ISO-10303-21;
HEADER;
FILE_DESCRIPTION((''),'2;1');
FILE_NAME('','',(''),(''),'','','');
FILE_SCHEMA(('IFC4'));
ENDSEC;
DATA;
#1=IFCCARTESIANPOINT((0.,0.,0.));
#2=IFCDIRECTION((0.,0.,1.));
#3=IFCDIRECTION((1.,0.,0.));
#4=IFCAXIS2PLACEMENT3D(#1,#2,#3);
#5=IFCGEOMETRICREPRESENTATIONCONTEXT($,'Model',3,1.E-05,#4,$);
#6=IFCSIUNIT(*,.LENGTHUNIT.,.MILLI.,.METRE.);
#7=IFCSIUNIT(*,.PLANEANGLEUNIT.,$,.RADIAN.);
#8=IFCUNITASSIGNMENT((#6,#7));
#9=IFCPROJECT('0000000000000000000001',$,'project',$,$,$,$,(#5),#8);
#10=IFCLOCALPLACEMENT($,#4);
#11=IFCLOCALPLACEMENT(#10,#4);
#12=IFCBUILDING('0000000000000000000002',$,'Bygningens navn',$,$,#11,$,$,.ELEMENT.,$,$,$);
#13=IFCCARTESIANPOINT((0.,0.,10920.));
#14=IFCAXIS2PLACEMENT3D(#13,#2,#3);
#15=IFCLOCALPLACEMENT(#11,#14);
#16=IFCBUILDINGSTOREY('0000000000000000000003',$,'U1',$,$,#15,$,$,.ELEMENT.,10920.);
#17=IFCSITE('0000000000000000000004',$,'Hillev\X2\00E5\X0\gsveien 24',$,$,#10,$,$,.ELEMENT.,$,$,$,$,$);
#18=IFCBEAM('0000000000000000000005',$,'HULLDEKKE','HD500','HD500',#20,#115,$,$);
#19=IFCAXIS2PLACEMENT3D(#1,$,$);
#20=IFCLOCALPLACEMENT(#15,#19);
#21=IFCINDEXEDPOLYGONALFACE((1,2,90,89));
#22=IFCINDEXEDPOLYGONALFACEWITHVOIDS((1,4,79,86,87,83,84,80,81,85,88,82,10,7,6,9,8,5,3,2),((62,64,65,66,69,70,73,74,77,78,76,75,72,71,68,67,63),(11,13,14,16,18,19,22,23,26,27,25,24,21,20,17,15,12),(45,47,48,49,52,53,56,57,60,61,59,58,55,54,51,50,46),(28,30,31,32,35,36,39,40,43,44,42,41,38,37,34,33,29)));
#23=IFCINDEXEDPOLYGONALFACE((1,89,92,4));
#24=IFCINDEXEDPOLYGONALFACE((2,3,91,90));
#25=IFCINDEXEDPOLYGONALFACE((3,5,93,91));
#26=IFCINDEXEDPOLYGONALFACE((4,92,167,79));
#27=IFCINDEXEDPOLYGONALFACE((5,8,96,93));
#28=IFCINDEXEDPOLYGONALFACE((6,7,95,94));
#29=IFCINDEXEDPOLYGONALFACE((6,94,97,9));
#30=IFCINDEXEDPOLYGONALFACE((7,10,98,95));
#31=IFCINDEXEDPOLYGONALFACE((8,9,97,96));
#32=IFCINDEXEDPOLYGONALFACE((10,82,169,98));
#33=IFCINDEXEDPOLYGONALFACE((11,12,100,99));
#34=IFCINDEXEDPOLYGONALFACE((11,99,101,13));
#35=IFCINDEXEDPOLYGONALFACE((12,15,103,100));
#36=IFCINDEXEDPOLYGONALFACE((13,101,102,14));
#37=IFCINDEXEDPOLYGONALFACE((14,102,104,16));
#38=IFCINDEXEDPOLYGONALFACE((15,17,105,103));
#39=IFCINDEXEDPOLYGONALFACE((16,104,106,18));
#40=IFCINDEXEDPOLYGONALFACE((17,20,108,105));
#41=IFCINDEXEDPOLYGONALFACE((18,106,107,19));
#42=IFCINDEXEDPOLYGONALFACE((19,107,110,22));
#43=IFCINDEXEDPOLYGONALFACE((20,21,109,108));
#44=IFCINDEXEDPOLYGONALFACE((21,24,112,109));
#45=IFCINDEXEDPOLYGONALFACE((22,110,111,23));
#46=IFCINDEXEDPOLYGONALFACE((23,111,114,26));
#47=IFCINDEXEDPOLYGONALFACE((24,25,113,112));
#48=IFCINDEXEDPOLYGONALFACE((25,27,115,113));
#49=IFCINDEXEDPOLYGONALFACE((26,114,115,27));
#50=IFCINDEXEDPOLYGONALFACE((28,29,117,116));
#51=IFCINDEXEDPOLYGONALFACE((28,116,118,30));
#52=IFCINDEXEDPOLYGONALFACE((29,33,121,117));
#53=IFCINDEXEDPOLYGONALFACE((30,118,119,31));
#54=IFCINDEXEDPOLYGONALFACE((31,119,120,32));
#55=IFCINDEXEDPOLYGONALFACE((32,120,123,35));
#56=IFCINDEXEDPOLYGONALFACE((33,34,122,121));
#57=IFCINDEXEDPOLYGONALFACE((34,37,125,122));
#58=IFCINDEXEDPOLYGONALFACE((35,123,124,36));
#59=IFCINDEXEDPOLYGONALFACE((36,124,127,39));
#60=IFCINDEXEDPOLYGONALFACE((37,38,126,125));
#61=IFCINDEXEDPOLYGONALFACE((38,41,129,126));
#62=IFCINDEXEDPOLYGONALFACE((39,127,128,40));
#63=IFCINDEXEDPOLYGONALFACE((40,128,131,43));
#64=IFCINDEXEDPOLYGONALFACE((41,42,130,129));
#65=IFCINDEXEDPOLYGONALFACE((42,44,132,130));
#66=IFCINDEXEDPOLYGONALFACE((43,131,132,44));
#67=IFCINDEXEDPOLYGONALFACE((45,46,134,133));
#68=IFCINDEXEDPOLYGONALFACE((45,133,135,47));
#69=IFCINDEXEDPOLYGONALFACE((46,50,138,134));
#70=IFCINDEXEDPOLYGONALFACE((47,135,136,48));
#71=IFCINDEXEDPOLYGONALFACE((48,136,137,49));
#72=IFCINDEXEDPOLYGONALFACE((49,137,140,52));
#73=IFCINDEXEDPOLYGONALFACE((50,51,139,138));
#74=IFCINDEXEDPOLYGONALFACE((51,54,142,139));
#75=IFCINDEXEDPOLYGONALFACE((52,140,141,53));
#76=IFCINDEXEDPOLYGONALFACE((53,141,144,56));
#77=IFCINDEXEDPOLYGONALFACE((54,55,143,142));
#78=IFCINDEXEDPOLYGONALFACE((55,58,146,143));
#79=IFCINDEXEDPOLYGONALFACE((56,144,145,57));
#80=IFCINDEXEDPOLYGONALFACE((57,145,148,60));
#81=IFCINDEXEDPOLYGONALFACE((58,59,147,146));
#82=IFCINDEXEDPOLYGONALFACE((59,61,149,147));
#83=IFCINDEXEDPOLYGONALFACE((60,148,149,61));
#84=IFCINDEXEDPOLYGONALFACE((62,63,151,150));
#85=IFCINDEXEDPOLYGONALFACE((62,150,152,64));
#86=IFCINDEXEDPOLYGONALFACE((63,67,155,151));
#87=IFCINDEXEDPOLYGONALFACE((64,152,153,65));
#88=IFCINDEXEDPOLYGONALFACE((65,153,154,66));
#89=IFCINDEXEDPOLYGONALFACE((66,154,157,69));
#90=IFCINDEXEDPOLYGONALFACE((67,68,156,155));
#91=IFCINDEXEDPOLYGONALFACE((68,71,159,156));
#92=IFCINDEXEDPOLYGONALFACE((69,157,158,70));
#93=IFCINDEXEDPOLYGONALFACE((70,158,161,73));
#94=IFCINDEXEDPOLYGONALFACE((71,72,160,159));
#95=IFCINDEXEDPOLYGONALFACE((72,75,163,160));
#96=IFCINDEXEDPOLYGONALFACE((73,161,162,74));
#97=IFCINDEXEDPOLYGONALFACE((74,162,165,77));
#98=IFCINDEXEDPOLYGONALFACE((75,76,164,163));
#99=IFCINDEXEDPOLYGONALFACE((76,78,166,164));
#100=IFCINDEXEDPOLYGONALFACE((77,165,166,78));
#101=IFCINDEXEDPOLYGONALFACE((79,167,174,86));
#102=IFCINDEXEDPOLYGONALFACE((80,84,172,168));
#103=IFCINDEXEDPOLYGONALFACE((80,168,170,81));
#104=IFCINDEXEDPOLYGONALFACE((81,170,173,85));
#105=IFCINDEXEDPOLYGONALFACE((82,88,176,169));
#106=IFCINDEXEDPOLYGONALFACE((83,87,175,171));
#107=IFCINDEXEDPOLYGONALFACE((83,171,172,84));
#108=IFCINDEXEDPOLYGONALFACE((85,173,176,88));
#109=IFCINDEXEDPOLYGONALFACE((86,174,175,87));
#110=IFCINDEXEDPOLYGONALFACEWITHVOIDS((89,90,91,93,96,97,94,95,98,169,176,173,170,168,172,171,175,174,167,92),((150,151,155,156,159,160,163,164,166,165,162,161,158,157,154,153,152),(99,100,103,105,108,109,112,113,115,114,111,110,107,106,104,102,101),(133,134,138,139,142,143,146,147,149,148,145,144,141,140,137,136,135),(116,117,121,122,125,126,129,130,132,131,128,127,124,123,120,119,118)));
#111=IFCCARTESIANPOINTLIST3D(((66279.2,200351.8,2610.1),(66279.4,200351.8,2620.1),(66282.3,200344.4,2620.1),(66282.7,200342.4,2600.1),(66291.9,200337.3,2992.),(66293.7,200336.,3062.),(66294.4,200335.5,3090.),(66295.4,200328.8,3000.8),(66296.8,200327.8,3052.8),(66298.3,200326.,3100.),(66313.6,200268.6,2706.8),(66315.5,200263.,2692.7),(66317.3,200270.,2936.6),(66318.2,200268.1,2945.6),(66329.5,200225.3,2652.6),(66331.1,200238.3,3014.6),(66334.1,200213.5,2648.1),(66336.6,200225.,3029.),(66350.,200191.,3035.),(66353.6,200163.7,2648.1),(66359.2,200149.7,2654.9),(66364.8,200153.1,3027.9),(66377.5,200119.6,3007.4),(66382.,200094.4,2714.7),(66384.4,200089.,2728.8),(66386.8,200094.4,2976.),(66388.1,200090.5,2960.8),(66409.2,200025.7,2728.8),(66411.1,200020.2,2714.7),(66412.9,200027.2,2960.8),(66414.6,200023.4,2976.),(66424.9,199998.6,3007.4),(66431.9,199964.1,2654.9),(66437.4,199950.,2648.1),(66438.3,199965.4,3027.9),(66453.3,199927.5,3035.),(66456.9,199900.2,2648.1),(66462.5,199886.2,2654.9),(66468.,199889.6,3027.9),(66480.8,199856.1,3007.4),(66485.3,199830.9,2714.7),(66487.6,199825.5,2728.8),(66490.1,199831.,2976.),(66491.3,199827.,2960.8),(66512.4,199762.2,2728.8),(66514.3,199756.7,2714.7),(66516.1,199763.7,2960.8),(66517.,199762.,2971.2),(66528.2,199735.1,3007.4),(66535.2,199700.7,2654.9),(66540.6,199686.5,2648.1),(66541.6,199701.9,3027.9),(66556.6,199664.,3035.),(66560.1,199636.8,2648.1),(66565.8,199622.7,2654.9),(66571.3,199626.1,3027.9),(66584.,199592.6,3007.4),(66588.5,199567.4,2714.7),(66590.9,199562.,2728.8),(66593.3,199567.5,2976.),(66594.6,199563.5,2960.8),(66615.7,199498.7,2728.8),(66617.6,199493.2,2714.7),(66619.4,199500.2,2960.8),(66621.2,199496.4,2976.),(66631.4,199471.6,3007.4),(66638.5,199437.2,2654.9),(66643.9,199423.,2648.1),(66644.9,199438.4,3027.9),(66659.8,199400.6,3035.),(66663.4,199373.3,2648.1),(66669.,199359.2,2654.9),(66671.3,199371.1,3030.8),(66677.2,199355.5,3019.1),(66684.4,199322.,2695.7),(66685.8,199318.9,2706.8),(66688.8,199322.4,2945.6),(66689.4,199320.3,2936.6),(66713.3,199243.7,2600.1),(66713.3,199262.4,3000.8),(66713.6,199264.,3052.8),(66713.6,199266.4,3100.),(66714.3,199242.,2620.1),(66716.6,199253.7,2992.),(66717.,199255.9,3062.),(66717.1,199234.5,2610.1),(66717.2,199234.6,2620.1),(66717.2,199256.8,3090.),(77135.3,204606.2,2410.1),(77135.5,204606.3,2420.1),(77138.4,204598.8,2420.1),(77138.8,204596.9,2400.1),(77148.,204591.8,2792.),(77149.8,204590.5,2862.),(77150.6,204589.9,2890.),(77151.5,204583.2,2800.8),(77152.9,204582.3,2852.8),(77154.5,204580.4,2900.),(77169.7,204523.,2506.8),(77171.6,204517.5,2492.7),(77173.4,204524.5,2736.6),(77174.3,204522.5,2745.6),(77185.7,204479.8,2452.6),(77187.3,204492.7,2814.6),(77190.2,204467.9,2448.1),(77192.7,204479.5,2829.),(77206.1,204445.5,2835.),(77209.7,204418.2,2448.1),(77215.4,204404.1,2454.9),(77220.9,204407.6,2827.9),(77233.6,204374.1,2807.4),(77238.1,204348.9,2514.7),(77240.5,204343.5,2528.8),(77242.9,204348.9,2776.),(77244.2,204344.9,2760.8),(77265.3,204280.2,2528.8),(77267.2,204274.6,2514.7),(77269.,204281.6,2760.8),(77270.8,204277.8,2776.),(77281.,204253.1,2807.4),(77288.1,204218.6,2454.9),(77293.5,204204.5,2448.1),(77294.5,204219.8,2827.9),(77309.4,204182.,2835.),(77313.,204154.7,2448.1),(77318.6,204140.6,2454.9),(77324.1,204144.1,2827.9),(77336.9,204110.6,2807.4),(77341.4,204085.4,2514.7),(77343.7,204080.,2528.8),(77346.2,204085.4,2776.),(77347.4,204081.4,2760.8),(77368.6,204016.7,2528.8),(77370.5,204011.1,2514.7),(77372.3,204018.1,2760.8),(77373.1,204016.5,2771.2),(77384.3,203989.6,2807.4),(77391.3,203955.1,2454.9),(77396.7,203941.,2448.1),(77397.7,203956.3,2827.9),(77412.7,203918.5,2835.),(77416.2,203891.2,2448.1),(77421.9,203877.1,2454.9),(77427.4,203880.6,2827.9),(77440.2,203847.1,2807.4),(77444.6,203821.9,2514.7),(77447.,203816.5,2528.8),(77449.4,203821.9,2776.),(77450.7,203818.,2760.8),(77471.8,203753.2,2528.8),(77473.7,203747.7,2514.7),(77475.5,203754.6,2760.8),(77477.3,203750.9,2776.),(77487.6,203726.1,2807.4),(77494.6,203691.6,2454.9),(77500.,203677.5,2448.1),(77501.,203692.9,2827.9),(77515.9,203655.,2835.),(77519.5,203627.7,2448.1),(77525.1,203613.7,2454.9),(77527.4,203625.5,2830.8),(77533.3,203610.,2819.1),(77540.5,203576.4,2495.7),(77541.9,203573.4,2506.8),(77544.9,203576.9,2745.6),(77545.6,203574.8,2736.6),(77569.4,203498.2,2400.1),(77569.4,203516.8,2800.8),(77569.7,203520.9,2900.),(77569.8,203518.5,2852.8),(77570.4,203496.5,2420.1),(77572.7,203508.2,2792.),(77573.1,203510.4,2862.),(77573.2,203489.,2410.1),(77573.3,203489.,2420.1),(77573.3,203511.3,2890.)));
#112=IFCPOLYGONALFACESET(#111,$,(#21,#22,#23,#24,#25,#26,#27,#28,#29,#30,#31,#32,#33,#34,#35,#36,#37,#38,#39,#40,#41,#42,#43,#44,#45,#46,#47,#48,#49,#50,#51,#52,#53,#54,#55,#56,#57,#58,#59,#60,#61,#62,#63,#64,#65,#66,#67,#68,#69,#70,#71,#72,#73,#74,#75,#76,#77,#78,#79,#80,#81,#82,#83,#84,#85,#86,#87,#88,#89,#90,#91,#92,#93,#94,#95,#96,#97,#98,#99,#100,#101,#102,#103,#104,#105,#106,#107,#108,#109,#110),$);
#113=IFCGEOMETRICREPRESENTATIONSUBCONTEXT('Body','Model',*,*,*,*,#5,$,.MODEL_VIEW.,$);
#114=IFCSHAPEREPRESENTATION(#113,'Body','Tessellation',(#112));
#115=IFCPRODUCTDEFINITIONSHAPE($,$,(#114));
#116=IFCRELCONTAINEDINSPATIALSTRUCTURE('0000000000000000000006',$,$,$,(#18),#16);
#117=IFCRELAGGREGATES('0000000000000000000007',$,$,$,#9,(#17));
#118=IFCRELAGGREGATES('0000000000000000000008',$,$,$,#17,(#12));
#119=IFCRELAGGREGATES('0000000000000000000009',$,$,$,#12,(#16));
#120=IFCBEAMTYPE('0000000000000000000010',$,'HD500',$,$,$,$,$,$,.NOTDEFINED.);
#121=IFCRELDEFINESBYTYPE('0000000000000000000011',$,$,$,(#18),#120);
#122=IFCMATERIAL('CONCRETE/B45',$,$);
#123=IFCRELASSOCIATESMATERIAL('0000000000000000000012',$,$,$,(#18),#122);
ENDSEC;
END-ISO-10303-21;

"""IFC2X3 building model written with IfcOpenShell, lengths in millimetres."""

from ifc_helpers import new_model, si_unit, frame, origin_with_axes, place, context, subcontext, project, spatial, polyline, outline, extrude, material, type_object, element, save


model = new_model("IFC2X3")

# Units and contexts
model_context = context("Model", 3, precision=1e-05, world=origin_with_axes())
body_context = subcontext(model_context, "Body", "Model", "MODEL_VIEW")
ifc_project = project(units=[si_unit("LENGTHUNIT", "METRE", prefix="MILLI"), si_unit("PLANEANGLEUNIT", "RADIAN")], contexts=[model_context])

# Site, building, storey
site_placement = place(None, origin_with_axes())
site = spatial("IfcSite", under=ifc_project, at=site_placement, Name="Hillevågsveien 24", CompositionType="ELEMENT")
building_placement = place(site_placement, origin_with_axes())
building = spatial("IfcBuilding", under=site, at=building_placement, Name="Bygningens navn", CompositionType="ELEMENT")
storey_placement = place(building_placement, frame((0.0, 0.0, 10920.0), z_axis=(0.0, 0.0, 1.0), x_axis=(1.0, 0.0, 0.0)))
storey = spatial("IfcBuildingStorey", under=building, at=storey_placement, Name="U1", CompositionType="ELEMENT", Elevation=10920.0)

# Beam
ifc_material_1 = material(Name="CONCRETE/B45")
beam_type_1 = type_object("IfcBeamType", Name="HD500", PredefinedType="NOTDEFINED")
beam_1_placement = place(storey_placement, frame((66502.0, 199794.6, 2850.0), z_axis=(0.015968, 0.006258, 0.999853), x_axis=(0.930919, 0.364823, -0.01715)))
element("IfcBeam", 1, at=beam_1_placement, inside=storey, type_object=beam_type_1, material=ifc_material_1, Name="HULLDEKKE", Description="HD500", ObjectType="HD500", context=body_context, shape_type="SweptSolid", body=[
    extrude(outline(polyline([(581.9, 142.0), (592.0, -230.0), (600.0, -230.0), (600.0, -240.0), (590.0, -250.0), (-590.0, -250.0), (-600.0, -240.0), (-600.0, -230.0), (-592.0, -230.0), (-581.9, 142.0), (-572.7, 150.7), (-571.3, 202.8), (-580.0, 212.0), (-579.3, 240.0), (-569.0, 250.0), (569.0, 250.0), (579.3, 240.0), (580.0, 212.0), (571.3, 202.8), (572.7, 150.7), (581.9, 142.0)]), holes=[polyline([(466.4, -195.1), (506.6, -154.3), (510.0, -143.2), (510.0, 86.5), (507.8, 95.6), (472.8, 169.1), (456.2, 180.7), (424.5, 185.0), (383.8, 177.9), (348.0, 157.4), (321.2, 126.0), (317.0, 110.8), (317.0, -121.2), (322.9, -135.4), (382.6, -195.1), (397.8, -202.0), (451.2, -202.0), (466.4, -195.1)]), polyline([(183.4, -195.1), (243.1, -135.4), (249.0, -121.2), (249.0, 110.8), (244.8, 126.0), (218.0, 157.4), (182.2, 177.9), (141.5, 185.0), (100.8, 177.9), (65.0, 157.4), (35.9, 121.2), (34.0, 110.8), (34.0, -121.2), (39.9, -135.4), (99.6, -195.1), (114.8, -202.0), (168.2, -202.0), (183.4, -195.1)]), polyline([(-99.6, -195.1), (-39.9, -135.4), (-34.0, -121.2), (-34.0, 110.8), (-38.2, 126.0), (-65.0, 157.4), (-100.8, 177.9), (-141.5, 185.0), (-182.2, 177.9), (-218.0, 157.4), (-244.8, 126.0), (-249.0, 110.8), (-249.0, -121.2), (-243.1, -135.4), (-183.4, -195.1), (-168.2, -202.0), (-114.8, -202.0), (-99.6, -195.1)]), polyline([(-382.6, -195.1), (-322.9, -135.4), (-317.0, -121.2), (-317.0, 110.8), (-321.2, 126.0), (-348.0, 157.4), (-383.8, 177.9), (-424.5, 185.0), (-461.0, 179.0), (-475.4, 164.6), (-507.9, 95.6), (-510.0, 86.5), (-510.0, -143.2), (-504.1, -157.4), (-463.9, -197.5), (-451.2, -202.0), (-397.8, -202.0), (-382.6, -195.1)])]), frame((11661.7, 0.0, 0.0), z_axis=(-1.0, 0.0, 0.0), x_axis=(0.0, -1.0, 0.0)), (0.0, 0.0, 1.0), 11661.7),
])

save(model, "model.ifc")
